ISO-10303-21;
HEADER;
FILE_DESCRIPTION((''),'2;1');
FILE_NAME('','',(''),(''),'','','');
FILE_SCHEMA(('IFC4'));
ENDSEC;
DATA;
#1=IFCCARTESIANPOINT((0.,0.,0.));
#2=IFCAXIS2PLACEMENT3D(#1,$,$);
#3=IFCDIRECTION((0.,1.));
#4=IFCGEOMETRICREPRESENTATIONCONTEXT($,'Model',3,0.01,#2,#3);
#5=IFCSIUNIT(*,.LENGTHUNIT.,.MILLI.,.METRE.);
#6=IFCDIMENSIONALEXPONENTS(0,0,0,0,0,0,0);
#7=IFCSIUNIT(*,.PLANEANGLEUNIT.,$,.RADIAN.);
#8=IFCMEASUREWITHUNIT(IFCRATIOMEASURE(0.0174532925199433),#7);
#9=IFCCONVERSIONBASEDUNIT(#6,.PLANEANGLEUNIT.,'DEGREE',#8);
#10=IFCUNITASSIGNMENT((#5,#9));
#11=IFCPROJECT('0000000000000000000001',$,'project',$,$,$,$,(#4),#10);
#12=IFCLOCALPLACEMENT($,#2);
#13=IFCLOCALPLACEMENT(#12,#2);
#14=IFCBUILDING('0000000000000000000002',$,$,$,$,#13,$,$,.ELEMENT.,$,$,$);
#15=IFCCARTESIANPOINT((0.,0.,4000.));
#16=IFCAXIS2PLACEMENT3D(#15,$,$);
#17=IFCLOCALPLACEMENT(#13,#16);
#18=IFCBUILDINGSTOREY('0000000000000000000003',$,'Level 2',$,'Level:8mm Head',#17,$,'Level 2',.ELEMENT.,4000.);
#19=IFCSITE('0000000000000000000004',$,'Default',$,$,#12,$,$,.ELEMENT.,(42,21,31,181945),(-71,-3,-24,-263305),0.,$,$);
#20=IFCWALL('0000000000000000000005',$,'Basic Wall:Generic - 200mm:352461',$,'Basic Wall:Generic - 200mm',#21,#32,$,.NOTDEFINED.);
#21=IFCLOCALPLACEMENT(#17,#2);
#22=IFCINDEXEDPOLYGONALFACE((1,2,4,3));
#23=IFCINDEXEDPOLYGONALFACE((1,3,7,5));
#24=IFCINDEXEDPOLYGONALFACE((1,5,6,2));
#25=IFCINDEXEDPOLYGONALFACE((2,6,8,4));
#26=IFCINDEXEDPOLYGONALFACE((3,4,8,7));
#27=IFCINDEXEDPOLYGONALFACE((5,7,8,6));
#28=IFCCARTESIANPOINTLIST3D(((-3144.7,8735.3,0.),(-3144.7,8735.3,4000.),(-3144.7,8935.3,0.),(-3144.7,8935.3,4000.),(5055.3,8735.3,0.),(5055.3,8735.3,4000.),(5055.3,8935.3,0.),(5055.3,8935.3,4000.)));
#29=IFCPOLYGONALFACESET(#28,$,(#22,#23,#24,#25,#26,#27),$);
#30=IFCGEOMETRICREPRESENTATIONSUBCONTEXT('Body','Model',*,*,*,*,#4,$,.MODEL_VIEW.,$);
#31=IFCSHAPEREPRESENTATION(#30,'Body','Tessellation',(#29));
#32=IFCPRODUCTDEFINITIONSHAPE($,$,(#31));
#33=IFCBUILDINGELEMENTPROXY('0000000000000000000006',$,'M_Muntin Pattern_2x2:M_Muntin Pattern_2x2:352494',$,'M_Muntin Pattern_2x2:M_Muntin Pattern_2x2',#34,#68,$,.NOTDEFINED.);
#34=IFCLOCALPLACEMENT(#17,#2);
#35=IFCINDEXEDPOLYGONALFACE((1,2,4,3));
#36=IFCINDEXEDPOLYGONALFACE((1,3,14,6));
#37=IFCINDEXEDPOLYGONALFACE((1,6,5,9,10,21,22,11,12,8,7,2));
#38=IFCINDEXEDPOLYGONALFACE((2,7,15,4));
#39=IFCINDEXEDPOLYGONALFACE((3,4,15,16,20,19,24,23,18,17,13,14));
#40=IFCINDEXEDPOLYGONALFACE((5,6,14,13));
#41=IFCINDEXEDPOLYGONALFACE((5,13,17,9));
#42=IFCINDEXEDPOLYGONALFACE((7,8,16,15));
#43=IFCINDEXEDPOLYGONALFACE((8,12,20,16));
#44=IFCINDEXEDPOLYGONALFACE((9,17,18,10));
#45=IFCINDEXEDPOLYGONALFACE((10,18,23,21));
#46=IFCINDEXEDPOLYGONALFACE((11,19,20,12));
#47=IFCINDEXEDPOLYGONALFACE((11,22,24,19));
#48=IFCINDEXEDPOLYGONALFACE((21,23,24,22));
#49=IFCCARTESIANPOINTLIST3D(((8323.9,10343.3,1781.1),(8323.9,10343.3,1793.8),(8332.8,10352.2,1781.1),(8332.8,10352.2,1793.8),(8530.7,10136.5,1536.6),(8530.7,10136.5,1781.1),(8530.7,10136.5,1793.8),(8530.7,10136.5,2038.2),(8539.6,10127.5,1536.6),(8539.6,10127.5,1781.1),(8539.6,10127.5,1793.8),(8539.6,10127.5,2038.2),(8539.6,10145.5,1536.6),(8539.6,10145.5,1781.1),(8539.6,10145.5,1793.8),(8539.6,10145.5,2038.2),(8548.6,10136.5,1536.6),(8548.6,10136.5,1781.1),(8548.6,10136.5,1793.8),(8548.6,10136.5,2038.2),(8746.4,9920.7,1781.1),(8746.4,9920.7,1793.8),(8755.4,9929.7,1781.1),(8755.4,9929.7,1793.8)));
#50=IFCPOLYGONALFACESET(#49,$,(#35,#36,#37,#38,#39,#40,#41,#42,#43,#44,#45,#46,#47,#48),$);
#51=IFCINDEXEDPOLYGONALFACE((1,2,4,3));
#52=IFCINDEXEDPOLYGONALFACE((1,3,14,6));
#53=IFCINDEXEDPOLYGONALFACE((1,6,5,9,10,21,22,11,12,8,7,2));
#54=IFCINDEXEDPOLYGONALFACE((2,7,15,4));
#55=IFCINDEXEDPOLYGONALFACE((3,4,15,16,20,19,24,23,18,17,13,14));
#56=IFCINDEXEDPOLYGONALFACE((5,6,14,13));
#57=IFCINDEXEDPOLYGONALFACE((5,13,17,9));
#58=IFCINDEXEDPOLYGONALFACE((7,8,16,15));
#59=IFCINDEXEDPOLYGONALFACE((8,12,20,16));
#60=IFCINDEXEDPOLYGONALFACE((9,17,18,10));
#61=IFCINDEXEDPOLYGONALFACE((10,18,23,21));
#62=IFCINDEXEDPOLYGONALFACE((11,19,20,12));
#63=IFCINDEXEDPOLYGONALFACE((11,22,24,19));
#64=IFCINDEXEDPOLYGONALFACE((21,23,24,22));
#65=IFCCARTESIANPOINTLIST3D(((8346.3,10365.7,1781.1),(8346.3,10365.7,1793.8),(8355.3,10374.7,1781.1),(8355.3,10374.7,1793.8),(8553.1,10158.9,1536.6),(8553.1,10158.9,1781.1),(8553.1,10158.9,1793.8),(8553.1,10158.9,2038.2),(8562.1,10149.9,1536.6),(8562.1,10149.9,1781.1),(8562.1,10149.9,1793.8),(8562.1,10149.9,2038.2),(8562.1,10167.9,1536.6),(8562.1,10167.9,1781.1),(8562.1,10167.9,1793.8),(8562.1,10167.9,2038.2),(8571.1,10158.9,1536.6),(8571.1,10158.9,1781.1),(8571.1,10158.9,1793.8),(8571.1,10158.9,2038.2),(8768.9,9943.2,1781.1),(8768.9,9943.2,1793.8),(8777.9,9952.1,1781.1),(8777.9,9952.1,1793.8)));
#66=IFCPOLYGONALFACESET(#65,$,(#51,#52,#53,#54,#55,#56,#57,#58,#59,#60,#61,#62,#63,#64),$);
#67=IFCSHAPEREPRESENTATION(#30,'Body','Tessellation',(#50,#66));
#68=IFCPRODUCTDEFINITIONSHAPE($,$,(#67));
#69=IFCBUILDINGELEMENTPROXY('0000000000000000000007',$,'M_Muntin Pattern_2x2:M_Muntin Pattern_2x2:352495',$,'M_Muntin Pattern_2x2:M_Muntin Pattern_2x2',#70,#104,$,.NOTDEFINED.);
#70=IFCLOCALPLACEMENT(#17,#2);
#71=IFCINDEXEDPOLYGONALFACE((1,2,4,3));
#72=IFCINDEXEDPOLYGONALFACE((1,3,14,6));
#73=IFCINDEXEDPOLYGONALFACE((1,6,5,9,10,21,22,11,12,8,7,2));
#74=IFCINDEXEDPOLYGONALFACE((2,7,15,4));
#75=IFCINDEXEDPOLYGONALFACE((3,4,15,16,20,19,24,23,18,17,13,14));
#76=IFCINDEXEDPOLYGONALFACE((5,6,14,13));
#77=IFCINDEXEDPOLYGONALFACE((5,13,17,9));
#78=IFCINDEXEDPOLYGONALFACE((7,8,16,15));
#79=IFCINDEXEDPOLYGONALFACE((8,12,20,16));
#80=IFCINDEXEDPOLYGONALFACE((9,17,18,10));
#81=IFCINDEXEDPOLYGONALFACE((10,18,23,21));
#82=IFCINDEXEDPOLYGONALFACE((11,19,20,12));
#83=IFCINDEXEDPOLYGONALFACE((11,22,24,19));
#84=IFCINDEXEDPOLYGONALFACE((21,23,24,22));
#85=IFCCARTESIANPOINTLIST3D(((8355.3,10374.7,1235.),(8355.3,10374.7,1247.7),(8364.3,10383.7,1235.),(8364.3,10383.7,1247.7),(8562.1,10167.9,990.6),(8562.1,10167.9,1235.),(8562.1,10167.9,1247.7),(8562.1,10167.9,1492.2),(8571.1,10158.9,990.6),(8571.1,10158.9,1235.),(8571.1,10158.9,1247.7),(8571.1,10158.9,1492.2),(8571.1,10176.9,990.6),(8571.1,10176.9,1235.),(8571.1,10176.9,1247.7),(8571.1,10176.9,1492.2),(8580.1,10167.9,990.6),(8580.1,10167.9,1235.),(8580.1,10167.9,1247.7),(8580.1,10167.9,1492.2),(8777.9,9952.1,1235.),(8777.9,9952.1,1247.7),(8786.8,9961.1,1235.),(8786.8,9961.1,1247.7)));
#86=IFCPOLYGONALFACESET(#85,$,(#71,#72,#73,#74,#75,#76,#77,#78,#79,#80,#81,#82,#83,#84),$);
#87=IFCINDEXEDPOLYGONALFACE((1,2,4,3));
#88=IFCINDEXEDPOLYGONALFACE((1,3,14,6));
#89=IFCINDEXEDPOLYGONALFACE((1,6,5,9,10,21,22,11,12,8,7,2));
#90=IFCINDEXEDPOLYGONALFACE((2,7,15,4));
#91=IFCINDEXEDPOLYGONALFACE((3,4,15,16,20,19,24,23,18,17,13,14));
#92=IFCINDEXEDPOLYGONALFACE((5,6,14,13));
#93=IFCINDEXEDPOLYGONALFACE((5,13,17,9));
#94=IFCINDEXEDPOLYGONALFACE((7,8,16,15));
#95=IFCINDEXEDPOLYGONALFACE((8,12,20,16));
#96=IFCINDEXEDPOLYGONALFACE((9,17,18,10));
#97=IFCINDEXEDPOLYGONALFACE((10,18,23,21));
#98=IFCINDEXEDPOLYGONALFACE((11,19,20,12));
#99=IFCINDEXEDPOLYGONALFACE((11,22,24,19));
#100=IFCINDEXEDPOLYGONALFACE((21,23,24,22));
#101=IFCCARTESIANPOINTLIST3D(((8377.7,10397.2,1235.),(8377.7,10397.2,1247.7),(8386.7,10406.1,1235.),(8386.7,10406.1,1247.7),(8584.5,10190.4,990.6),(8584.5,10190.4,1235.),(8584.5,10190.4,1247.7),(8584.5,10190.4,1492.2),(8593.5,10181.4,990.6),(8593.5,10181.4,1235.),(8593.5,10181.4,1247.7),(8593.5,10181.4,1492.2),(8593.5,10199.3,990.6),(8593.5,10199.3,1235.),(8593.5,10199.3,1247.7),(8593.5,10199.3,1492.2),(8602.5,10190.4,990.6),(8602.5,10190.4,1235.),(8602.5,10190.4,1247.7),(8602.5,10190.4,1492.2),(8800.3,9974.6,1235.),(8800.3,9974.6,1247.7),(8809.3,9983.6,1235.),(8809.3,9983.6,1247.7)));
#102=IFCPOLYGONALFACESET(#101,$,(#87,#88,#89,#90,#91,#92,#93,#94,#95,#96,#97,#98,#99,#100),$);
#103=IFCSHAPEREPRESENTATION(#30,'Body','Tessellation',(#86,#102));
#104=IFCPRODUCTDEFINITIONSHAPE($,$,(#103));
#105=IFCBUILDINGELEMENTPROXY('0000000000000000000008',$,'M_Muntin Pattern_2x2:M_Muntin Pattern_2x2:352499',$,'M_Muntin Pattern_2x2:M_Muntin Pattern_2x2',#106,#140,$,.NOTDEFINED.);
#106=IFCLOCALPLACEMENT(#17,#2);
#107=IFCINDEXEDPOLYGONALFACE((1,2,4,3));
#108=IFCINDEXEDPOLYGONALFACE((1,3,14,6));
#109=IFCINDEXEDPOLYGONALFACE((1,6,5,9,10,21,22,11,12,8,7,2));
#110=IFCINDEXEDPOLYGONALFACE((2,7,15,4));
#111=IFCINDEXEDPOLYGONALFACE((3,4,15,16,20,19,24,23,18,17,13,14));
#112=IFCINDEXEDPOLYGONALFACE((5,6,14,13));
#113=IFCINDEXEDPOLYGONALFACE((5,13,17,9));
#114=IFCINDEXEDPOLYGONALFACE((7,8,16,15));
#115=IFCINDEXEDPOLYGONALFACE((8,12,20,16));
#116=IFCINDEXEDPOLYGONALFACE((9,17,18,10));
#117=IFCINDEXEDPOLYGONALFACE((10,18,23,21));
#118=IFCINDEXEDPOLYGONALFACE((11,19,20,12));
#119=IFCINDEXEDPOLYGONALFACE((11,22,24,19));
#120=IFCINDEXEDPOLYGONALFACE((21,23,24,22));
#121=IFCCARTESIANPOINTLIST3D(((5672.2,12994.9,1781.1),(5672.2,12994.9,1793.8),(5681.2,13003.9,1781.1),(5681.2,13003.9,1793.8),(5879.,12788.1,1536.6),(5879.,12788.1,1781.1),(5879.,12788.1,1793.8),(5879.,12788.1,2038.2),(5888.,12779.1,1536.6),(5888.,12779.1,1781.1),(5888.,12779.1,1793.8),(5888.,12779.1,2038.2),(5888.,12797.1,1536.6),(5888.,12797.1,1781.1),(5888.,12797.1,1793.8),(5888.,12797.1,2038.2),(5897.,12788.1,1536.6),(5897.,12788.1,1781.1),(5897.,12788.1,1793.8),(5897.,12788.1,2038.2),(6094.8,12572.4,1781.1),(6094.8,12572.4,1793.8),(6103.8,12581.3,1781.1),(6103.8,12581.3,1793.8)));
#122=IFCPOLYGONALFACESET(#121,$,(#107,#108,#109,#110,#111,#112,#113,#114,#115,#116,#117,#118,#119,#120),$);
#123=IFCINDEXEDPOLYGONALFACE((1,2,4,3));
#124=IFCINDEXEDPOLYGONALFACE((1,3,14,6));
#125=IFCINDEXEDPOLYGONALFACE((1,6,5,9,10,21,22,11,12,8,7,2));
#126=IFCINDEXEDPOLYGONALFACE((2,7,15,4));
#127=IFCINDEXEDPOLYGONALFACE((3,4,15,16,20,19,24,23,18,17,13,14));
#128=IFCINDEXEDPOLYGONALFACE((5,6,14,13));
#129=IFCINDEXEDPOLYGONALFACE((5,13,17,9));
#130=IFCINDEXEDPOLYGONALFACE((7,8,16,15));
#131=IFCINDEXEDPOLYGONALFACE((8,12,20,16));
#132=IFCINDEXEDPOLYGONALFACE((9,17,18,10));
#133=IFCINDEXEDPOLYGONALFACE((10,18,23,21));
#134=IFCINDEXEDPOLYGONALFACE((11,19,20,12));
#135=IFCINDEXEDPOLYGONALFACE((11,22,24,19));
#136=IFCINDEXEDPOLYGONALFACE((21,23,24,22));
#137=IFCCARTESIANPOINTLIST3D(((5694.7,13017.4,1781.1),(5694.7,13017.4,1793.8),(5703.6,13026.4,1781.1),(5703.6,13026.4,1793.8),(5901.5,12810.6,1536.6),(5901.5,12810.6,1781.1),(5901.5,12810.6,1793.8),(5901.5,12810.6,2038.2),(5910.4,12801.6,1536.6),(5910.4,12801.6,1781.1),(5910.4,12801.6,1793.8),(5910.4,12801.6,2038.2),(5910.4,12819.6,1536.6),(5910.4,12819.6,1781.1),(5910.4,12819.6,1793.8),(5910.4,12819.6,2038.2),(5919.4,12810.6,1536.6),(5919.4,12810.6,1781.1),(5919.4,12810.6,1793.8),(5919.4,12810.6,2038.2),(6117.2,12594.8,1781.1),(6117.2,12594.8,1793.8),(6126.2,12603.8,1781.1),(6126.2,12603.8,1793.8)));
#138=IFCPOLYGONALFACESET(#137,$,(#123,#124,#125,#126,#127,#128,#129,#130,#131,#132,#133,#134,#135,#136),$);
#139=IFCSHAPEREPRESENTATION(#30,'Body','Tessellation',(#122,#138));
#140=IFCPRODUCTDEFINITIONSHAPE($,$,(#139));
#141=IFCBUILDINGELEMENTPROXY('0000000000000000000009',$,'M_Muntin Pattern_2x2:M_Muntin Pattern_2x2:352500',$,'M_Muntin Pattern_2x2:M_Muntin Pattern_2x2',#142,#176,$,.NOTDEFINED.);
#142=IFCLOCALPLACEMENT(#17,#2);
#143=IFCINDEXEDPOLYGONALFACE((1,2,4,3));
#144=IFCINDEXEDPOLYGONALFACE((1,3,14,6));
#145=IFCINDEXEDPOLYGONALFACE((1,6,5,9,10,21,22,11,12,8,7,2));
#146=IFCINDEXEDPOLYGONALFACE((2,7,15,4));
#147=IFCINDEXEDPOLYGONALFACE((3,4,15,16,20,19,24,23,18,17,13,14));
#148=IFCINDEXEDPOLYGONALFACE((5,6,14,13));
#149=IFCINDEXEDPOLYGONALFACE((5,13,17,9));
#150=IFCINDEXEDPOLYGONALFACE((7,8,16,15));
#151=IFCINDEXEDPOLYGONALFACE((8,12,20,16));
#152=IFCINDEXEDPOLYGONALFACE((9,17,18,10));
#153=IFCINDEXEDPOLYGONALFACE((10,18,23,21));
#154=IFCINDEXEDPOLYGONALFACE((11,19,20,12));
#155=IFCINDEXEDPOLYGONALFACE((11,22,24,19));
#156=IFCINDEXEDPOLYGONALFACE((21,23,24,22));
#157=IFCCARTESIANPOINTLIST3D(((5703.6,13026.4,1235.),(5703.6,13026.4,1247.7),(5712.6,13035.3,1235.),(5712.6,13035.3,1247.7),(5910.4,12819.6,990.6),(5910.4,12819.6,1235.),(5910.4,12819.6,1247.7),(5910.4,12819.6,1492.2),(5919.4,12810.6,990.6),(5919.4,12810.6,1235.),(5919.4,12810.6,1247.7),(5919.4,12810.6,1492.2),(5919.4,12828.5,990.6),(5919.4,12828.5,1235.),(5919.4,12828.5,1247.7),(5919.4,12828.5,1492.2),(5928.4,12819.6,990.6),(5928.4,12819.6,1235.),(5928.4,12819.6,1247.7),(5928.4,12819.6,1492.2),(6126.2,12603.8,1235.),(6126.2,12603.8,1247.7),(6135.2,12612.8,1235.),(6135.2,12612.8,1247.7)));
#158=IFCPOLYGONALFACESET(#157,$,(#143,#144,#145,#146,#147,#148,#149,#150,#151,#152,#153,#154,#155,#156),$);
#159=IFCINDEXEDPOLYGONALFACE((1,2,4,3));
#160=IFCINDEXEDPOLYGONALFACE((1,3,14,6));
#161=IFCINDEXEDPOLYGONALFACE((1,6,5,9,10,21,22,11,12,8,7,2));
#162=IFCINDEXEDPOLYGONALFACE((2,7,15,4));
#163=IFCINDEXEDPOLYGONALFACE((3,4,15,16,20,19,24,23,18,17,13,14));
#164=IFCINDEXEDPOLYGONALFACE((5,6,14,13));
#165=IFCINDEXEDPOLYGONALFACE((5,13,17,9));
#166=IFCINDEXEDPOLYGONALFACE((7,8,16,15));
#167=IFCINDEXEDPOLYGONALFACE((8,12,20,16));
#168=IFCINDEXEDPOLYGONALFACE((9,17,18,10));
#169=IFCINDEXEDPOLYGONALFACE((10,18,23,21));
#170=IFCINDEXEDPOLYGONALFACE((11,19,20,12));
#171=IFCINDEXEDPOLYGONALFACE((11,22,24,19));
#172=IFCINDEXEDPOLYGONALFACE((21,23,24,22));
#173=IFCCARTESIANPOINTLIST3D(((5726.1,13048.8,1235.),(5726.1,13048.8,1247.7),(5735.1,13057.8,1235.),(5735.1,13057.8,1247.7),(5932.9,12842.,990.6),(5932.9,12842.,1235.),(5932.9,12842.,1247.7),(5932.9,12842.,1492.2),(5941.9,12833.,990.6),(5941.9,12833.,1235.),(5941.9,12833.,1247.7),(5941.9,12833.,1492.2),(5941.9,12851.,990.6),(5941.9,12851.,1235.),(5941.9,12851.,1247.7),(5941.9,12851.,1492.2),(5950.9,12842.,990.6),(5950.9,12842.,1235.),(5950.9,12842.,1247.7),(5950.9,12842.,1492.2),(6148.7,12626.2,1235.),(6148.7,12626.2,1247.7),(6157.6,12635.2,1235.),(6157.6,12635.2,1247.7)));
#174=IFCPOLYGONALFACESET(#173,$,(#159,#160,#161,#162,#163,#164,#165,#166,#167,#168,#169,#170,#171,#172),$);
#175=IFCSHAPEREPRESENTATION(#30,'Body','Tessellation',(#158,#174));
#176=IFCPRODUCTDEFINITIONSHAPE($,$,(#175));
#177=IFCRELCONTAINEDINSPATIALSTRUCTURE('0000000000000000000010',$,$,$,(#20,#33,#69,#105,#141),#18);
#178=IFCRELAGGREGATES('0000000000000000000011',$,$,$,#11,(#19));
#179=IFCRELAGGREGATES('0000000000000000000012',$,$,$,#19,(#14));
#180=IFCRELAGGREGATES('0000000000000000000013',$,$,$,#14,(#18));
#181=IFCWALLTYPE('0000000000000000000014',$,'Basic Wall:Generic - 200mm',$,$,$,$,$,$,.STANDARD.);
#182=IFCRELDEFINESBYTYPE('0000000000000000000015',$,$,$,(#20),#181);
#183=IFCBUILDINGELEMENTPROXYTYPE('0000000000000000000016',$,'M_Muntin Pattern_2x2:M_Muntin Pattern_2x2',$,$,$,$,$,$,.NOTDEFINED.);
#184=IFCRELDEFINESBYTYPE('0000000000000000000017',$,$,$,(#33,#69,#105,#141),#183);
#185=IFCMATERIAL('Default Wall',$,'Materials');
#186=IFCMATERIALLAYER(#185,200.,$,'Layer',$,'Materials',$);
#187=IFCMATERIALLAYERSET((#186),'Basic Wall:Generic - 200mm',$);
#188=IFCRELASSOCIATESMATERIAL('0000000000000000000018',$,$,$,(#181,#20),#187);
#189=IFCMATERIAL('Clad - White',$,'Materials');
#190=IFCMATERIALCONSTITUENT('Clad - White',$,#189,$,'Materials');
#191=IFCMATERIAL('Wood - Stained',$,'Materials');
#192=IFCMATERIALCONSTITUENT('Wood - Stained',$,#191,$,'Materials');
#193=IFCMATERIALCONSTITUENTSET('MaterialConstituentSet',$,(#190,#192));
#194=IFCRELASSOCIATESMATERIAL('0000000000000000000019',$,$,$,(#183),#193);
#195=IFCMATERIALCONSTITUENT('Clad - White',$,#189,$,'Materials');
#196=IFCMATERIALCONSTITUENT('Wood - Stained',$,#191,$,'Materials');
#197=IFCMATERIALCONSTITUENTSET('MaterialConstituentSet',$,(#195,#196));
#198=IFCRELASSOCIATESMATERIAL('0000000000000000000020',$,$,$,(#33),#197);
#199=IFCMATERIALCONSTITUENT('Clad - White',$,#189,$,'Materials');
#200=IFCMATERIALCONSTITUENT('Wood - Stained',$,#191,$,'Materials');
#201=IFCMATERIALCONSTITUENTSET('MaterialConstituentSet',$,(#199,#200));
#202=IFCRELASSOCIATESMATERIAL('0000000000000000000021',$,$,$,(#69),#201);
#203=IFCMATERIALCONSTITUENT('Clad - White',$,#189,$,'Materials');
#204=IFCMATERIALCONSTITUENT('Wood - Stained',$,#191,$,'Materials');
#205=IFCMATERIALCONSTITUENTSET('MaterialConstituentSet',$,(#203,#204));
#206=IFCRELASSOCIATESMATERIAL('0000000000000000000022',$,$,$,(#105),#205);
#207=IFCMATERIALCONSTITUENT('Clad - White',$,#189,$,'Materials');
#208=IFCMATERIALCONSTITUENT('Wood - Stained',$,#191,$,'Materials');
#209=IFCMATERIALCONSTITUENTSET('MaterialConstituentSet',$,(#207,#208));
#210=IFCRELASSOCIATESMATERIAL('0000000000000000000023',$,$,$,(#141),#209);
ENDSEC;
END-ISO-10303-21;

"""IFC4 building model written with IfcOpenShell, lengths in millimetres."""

from ifc_helpers import new_model, entity, si_unit, converted_unit, direction, frame, frame_2d, origin, place, context, subcontext, project, spatial, polyline, rectangle, outline, extrude, source, transform, mapped, material, layer, layer_set, layer_usage, constituent, constituent_set, type_object, type_shapes, element, save


model = new_model("IFC4")

# Units and contexts
model_context = context("Model", 3, precision=0.01, world=origin(), true_north=direction((0.0, 1.0)))
body_context = subcontext(model_context, "Body", "Model", "MODEL_VIEW")
ifc_project = project(units=[si_unit("LENGTHUNIT", "METRE", prefix="MILLI"), converted_unit("PLANEANGLEUNIT", "DEGREE", entity("IfcRatioMeasure", 0.0174532925199433), si_unit("PLANEANGLEUNIT", "RADIAN"), dimensions=[0, 0, 0, 0, 0, 0, 0])], contexts=[model_context])

# Site, building, storey
site_placement = place(None, origin())
site = spatial("IfcSite", under=ifc_project, at=site_placement, Name="Default", CompositionType="ELEMENT", RefLatitude=(42, 21, 31, 181945), RefLongitude=(-71, -3, -24, -263305), RefElevation=0.0)
building_placement = place(site_placement, origin())
building = spatial("IfcBuilding", under=site, at=building_placement, CompositionType="ELEMENT")
storey_placement = place(building_placement, frame((0.0, 0.0, 4000.0)))
storey = spatial("IfcBuildingStorey", under=building, at=storey_placement, Name="Level 2", ObjectType="Level:8mm Head", LongName="Level 2", CompositionType="ELEMENT", Elevation=4000.0)

# Shared definitions
ifc_material_1 = material(Name="Default Wall", Category="Materials")
ifc_layer = layer(ifc_material_1, 200.0, Name="Layer", Category="Materials")
ifc_layer_set = layer_set([ifc_layer], Name="Basic Wall:Generic - 200mm")
wall_type = type_object("IfcWallType", Name="Basic Wall:Generic - 200mm", PredefinedType="STANDARD", material=ifc_layer_set)
ifc_material_2 = material(Name="Wood - Stained", Category="Materials")

# Wall
ifc_layer_usage_1 = layer_usage(ifc_layer_set, "AXIS2", "NEGATIVE", 100.0)
wall_1_placement = place(storey_placement, frame((5055.3, 8835.3, 0.0), z_axis=(0.0, 0.0, 1.0), x_axis=(-1.0, 0.0, 0.0)))
element("IfcWall", 1, at=wall_1_placement, inside=storey, type_object=wall_type, material=ifc_layer_usage_1, Name="Basic Wall:Generic - 200mm:352461", ObjectType="Basic Wall:Generic - 200mm", PredefinedType="NOTDEFINED", context=body_context, shape_type="SweptSolid", body=[
    extrude(rectangle(XDim=8200.0, YDim=200.0, at=frame_2d((4100.0, 0.0), x_axis=(-1.0, 0.0))), origin(), (0.0, 0.0, 1.0), 4000.0),
])

# Building element proxies
ifc_material_3 = material(Name="Clad - White", Category="Materials")
ifc_constituent_1 = constituent(ifc_material_3, Name="Clad - White", Category="Materials")
ifc_constituent_2 = constituent(ifc_material_2, Name="Wood - Stained", Category="Materials")
ifc_constituent_set_1 = constituent_set(constituents=[ifc_constituent_1, ifc_constituent_2], Name="MaterialConstituentSet")
ifc_constituent_3 = constituent(ifc_material_3, Name="Clad - White", Category="Materials")
ifc_constituent_4 = constituent(ifc_material_2, Name="Wood - Stained", Category="Materials")
ifc_constituent_set_2 = constituent_set(constituents=[ifc_constituent_3, ifc_constituent_4], Name="MaterialConstituentSet")
building_element_proxy_type_1 = type_object("IfcBuildingElementProxyType", Name="M_Muntin Pattern_2x2:M_Muntin Pattern_2x2", PredefinedType="NOTDEFINED", material=ifc_constituent_set_2)
shared_shape_1 = source(origin(), body_context, "Body", "SweptSolid", [
    extrude(outline(polyline([(6.4, -6.4), (250.8, -6.4), (250.8, 6.3), (6.4, 6.3), (6.4, 298.8), (-6.3, 298.8), (-6.3, 6.3), (-250.8, 6.3), (-250.8, -6.4), (-6.3, -6.4), (-6.3, -298.8), (6.4, -298.8), (6.4, -6.4)])), frame((0.0, 9.5, 250.8), z_axis=(0.0, 1.0, 0.0), x_axis=(0.0, 0.0, 1.0)), (0.0, 0.0, 1.0), 12.7),
    extrude(outline(polyline([(6.4, -6.4), (250.8, -6.4), (250.8, 6.3), (6.4, 6.3), (6.4, 298.8), (-6.3, 298.8), (-6.3, 6.3), (-250.8, 6.3), (-250.8, -6.4), (-6.3, -6.4), (-6.3, -298.8), (6.4, -298.8), (6.4, -6.4)])), frame((0.0, -22.2, 250.8), z_axis=(0.0, 1.0, 0.0), x_axis=(0.0, 0.0, 1.0)), (0.0, 0.0, 1.0), 12.7),
])
type_shapes(building_element_proxy_type_1, [shared_shape_1])
proxy_1_placement = place(storey_placement, frame((8550.9, 10147.7, 1536.6), z_axis=(0.0, 0.0, 1.0), x_axis=(-0.707107, 0.707107, 0.0)))
element("IfcBuildingElementProxy", 2, at=proxy_1_placement, inside=storey, type_object=building_element_proxy_type_1, material=ifc_constituent_set_1, Name="M_Muntin Pattern_2x2:M_Muntin Pattern_2x2:352494", ObjectType="M_Muntin Pattern_2x2:M_Muntin Pattern_2x2", PredefinedType="NOTDEFINED", context=body_context, shape_type="MappedRepresentation", body=[
    mapped(shared_shape_1, transform((0.0, 0.0, 0.0), scale=1.0)),
])
ifc_constituent_5 = constituent(ifc_material_3, Name="Clad - White", Category="Materials")
ifc_constituent_6 = constituent(ifc_material_2, Name="Wood - Stained", Category="Materials")
ifc_constituent_set_3 = constituent_set(constituents=[ifc_constituent_5, ifc_constituent_6], Name="MaterialConstituentSet")
proxy_2_placement = place(storey_placement, frame((8582.3, 10179.1, 990.6), z_axis=(0.0, 0.0, 1.0), x_axis=(-0.707107, 0.707107, 0.0)))
element("IfcBuildingElementProxy", 3, at=proxy_2_placement, inside=storey, type_object=building_element_proxy_type_1, material=ifc_constituent_set_3, Name="M_Muntin Pattern_2x2:M_Muntin Pattern_2x2:352495", ObjectType="M_Muntin Pattern_2x2:M_Muntin Pattern_2x2", PredefinedType="NOTDEFINED", context=body_context, shape_type="MappedRepresentation", body=[
    mapped(shared_shape_1, transform((0.0, 0.0, 0.0), scale=1.0)),
])
ifc_constituent_7 = constituent(ifc_material_3, Name="Clad - White", Category="Materials")
ifc_constituent_8 = constituent(ifc_material_2, Name="Wood - Stained", Category="Materials")
ifc_constituent_set_4 = constituent_set(constituents=[ifc_constituent_7, ifc_constituent_8], Name="MaterialConstituentSet")
proxy_3_placement = place(storey_placement, frame((5899.2, 12799.4, 1536.6), z_axis=(0.0, 0.0, 1.0), x_axis=(-0.707107, 0.707107, 0.0)))
element("IfcBuildingElementProxy", 4, at=proxy_3_placement, inside=storey, type_object=building_element_proxy_type_1, material=ifc_constituent_set_4, Name="M_Muntin Pattern_2x2:M_Muntin Pattern_2x2:352499", ObjectType="M_Muntin Pattern_2x2:M_Muntin Pattern_2x2", PredefinedType="NOTDEFINED", context=body_context, shape_type="MappedRepresentation", body=[
    mapped(shared_shape_1, transform((0.0, 0.0, 0.0), scale=1.0)),
])
ifc_constituent_9 = constituent(ifc_material_3, Name="Clad - White", Category="Materials")
ifc_constituent_10 = constituent(ifc_material_2, Name="Wood - Stained", Category="Materials")
ifc_constituent_set_5 = constituent_set(constituents=[ifc_constituent_9, ifc_constituent_10], Name="MaterialConstituentSet")
proxy_4_placement = place(storey_placement, frame((5930.6, 12830.8, 990.6), z_axis=(0.0, 0.0, 1.0), x_axis=(-0.707107, 0.707107, 0.0)))
element("IfcBuildingElementProxy", 5, at=proxy_4_placement, inside=storey, type_object=building_element_proxy_type_1, material=ifc_constituent_set_5, Name="M_Muntin Pattern_2x2:M_Muntin Pattern_2x2:352500", ObjectType="M_Muntin Pattern_2x2:M_Muntin Pattern_2x2", PredefinedType="NOTDEFINED", context=body_context, shape_type="MappedRepresentation", body=[
    mapped(shared_shape_1, transform((0.0, 0.0, 0.0), scale=1.0)),
])

save(model, "model.ifc")
